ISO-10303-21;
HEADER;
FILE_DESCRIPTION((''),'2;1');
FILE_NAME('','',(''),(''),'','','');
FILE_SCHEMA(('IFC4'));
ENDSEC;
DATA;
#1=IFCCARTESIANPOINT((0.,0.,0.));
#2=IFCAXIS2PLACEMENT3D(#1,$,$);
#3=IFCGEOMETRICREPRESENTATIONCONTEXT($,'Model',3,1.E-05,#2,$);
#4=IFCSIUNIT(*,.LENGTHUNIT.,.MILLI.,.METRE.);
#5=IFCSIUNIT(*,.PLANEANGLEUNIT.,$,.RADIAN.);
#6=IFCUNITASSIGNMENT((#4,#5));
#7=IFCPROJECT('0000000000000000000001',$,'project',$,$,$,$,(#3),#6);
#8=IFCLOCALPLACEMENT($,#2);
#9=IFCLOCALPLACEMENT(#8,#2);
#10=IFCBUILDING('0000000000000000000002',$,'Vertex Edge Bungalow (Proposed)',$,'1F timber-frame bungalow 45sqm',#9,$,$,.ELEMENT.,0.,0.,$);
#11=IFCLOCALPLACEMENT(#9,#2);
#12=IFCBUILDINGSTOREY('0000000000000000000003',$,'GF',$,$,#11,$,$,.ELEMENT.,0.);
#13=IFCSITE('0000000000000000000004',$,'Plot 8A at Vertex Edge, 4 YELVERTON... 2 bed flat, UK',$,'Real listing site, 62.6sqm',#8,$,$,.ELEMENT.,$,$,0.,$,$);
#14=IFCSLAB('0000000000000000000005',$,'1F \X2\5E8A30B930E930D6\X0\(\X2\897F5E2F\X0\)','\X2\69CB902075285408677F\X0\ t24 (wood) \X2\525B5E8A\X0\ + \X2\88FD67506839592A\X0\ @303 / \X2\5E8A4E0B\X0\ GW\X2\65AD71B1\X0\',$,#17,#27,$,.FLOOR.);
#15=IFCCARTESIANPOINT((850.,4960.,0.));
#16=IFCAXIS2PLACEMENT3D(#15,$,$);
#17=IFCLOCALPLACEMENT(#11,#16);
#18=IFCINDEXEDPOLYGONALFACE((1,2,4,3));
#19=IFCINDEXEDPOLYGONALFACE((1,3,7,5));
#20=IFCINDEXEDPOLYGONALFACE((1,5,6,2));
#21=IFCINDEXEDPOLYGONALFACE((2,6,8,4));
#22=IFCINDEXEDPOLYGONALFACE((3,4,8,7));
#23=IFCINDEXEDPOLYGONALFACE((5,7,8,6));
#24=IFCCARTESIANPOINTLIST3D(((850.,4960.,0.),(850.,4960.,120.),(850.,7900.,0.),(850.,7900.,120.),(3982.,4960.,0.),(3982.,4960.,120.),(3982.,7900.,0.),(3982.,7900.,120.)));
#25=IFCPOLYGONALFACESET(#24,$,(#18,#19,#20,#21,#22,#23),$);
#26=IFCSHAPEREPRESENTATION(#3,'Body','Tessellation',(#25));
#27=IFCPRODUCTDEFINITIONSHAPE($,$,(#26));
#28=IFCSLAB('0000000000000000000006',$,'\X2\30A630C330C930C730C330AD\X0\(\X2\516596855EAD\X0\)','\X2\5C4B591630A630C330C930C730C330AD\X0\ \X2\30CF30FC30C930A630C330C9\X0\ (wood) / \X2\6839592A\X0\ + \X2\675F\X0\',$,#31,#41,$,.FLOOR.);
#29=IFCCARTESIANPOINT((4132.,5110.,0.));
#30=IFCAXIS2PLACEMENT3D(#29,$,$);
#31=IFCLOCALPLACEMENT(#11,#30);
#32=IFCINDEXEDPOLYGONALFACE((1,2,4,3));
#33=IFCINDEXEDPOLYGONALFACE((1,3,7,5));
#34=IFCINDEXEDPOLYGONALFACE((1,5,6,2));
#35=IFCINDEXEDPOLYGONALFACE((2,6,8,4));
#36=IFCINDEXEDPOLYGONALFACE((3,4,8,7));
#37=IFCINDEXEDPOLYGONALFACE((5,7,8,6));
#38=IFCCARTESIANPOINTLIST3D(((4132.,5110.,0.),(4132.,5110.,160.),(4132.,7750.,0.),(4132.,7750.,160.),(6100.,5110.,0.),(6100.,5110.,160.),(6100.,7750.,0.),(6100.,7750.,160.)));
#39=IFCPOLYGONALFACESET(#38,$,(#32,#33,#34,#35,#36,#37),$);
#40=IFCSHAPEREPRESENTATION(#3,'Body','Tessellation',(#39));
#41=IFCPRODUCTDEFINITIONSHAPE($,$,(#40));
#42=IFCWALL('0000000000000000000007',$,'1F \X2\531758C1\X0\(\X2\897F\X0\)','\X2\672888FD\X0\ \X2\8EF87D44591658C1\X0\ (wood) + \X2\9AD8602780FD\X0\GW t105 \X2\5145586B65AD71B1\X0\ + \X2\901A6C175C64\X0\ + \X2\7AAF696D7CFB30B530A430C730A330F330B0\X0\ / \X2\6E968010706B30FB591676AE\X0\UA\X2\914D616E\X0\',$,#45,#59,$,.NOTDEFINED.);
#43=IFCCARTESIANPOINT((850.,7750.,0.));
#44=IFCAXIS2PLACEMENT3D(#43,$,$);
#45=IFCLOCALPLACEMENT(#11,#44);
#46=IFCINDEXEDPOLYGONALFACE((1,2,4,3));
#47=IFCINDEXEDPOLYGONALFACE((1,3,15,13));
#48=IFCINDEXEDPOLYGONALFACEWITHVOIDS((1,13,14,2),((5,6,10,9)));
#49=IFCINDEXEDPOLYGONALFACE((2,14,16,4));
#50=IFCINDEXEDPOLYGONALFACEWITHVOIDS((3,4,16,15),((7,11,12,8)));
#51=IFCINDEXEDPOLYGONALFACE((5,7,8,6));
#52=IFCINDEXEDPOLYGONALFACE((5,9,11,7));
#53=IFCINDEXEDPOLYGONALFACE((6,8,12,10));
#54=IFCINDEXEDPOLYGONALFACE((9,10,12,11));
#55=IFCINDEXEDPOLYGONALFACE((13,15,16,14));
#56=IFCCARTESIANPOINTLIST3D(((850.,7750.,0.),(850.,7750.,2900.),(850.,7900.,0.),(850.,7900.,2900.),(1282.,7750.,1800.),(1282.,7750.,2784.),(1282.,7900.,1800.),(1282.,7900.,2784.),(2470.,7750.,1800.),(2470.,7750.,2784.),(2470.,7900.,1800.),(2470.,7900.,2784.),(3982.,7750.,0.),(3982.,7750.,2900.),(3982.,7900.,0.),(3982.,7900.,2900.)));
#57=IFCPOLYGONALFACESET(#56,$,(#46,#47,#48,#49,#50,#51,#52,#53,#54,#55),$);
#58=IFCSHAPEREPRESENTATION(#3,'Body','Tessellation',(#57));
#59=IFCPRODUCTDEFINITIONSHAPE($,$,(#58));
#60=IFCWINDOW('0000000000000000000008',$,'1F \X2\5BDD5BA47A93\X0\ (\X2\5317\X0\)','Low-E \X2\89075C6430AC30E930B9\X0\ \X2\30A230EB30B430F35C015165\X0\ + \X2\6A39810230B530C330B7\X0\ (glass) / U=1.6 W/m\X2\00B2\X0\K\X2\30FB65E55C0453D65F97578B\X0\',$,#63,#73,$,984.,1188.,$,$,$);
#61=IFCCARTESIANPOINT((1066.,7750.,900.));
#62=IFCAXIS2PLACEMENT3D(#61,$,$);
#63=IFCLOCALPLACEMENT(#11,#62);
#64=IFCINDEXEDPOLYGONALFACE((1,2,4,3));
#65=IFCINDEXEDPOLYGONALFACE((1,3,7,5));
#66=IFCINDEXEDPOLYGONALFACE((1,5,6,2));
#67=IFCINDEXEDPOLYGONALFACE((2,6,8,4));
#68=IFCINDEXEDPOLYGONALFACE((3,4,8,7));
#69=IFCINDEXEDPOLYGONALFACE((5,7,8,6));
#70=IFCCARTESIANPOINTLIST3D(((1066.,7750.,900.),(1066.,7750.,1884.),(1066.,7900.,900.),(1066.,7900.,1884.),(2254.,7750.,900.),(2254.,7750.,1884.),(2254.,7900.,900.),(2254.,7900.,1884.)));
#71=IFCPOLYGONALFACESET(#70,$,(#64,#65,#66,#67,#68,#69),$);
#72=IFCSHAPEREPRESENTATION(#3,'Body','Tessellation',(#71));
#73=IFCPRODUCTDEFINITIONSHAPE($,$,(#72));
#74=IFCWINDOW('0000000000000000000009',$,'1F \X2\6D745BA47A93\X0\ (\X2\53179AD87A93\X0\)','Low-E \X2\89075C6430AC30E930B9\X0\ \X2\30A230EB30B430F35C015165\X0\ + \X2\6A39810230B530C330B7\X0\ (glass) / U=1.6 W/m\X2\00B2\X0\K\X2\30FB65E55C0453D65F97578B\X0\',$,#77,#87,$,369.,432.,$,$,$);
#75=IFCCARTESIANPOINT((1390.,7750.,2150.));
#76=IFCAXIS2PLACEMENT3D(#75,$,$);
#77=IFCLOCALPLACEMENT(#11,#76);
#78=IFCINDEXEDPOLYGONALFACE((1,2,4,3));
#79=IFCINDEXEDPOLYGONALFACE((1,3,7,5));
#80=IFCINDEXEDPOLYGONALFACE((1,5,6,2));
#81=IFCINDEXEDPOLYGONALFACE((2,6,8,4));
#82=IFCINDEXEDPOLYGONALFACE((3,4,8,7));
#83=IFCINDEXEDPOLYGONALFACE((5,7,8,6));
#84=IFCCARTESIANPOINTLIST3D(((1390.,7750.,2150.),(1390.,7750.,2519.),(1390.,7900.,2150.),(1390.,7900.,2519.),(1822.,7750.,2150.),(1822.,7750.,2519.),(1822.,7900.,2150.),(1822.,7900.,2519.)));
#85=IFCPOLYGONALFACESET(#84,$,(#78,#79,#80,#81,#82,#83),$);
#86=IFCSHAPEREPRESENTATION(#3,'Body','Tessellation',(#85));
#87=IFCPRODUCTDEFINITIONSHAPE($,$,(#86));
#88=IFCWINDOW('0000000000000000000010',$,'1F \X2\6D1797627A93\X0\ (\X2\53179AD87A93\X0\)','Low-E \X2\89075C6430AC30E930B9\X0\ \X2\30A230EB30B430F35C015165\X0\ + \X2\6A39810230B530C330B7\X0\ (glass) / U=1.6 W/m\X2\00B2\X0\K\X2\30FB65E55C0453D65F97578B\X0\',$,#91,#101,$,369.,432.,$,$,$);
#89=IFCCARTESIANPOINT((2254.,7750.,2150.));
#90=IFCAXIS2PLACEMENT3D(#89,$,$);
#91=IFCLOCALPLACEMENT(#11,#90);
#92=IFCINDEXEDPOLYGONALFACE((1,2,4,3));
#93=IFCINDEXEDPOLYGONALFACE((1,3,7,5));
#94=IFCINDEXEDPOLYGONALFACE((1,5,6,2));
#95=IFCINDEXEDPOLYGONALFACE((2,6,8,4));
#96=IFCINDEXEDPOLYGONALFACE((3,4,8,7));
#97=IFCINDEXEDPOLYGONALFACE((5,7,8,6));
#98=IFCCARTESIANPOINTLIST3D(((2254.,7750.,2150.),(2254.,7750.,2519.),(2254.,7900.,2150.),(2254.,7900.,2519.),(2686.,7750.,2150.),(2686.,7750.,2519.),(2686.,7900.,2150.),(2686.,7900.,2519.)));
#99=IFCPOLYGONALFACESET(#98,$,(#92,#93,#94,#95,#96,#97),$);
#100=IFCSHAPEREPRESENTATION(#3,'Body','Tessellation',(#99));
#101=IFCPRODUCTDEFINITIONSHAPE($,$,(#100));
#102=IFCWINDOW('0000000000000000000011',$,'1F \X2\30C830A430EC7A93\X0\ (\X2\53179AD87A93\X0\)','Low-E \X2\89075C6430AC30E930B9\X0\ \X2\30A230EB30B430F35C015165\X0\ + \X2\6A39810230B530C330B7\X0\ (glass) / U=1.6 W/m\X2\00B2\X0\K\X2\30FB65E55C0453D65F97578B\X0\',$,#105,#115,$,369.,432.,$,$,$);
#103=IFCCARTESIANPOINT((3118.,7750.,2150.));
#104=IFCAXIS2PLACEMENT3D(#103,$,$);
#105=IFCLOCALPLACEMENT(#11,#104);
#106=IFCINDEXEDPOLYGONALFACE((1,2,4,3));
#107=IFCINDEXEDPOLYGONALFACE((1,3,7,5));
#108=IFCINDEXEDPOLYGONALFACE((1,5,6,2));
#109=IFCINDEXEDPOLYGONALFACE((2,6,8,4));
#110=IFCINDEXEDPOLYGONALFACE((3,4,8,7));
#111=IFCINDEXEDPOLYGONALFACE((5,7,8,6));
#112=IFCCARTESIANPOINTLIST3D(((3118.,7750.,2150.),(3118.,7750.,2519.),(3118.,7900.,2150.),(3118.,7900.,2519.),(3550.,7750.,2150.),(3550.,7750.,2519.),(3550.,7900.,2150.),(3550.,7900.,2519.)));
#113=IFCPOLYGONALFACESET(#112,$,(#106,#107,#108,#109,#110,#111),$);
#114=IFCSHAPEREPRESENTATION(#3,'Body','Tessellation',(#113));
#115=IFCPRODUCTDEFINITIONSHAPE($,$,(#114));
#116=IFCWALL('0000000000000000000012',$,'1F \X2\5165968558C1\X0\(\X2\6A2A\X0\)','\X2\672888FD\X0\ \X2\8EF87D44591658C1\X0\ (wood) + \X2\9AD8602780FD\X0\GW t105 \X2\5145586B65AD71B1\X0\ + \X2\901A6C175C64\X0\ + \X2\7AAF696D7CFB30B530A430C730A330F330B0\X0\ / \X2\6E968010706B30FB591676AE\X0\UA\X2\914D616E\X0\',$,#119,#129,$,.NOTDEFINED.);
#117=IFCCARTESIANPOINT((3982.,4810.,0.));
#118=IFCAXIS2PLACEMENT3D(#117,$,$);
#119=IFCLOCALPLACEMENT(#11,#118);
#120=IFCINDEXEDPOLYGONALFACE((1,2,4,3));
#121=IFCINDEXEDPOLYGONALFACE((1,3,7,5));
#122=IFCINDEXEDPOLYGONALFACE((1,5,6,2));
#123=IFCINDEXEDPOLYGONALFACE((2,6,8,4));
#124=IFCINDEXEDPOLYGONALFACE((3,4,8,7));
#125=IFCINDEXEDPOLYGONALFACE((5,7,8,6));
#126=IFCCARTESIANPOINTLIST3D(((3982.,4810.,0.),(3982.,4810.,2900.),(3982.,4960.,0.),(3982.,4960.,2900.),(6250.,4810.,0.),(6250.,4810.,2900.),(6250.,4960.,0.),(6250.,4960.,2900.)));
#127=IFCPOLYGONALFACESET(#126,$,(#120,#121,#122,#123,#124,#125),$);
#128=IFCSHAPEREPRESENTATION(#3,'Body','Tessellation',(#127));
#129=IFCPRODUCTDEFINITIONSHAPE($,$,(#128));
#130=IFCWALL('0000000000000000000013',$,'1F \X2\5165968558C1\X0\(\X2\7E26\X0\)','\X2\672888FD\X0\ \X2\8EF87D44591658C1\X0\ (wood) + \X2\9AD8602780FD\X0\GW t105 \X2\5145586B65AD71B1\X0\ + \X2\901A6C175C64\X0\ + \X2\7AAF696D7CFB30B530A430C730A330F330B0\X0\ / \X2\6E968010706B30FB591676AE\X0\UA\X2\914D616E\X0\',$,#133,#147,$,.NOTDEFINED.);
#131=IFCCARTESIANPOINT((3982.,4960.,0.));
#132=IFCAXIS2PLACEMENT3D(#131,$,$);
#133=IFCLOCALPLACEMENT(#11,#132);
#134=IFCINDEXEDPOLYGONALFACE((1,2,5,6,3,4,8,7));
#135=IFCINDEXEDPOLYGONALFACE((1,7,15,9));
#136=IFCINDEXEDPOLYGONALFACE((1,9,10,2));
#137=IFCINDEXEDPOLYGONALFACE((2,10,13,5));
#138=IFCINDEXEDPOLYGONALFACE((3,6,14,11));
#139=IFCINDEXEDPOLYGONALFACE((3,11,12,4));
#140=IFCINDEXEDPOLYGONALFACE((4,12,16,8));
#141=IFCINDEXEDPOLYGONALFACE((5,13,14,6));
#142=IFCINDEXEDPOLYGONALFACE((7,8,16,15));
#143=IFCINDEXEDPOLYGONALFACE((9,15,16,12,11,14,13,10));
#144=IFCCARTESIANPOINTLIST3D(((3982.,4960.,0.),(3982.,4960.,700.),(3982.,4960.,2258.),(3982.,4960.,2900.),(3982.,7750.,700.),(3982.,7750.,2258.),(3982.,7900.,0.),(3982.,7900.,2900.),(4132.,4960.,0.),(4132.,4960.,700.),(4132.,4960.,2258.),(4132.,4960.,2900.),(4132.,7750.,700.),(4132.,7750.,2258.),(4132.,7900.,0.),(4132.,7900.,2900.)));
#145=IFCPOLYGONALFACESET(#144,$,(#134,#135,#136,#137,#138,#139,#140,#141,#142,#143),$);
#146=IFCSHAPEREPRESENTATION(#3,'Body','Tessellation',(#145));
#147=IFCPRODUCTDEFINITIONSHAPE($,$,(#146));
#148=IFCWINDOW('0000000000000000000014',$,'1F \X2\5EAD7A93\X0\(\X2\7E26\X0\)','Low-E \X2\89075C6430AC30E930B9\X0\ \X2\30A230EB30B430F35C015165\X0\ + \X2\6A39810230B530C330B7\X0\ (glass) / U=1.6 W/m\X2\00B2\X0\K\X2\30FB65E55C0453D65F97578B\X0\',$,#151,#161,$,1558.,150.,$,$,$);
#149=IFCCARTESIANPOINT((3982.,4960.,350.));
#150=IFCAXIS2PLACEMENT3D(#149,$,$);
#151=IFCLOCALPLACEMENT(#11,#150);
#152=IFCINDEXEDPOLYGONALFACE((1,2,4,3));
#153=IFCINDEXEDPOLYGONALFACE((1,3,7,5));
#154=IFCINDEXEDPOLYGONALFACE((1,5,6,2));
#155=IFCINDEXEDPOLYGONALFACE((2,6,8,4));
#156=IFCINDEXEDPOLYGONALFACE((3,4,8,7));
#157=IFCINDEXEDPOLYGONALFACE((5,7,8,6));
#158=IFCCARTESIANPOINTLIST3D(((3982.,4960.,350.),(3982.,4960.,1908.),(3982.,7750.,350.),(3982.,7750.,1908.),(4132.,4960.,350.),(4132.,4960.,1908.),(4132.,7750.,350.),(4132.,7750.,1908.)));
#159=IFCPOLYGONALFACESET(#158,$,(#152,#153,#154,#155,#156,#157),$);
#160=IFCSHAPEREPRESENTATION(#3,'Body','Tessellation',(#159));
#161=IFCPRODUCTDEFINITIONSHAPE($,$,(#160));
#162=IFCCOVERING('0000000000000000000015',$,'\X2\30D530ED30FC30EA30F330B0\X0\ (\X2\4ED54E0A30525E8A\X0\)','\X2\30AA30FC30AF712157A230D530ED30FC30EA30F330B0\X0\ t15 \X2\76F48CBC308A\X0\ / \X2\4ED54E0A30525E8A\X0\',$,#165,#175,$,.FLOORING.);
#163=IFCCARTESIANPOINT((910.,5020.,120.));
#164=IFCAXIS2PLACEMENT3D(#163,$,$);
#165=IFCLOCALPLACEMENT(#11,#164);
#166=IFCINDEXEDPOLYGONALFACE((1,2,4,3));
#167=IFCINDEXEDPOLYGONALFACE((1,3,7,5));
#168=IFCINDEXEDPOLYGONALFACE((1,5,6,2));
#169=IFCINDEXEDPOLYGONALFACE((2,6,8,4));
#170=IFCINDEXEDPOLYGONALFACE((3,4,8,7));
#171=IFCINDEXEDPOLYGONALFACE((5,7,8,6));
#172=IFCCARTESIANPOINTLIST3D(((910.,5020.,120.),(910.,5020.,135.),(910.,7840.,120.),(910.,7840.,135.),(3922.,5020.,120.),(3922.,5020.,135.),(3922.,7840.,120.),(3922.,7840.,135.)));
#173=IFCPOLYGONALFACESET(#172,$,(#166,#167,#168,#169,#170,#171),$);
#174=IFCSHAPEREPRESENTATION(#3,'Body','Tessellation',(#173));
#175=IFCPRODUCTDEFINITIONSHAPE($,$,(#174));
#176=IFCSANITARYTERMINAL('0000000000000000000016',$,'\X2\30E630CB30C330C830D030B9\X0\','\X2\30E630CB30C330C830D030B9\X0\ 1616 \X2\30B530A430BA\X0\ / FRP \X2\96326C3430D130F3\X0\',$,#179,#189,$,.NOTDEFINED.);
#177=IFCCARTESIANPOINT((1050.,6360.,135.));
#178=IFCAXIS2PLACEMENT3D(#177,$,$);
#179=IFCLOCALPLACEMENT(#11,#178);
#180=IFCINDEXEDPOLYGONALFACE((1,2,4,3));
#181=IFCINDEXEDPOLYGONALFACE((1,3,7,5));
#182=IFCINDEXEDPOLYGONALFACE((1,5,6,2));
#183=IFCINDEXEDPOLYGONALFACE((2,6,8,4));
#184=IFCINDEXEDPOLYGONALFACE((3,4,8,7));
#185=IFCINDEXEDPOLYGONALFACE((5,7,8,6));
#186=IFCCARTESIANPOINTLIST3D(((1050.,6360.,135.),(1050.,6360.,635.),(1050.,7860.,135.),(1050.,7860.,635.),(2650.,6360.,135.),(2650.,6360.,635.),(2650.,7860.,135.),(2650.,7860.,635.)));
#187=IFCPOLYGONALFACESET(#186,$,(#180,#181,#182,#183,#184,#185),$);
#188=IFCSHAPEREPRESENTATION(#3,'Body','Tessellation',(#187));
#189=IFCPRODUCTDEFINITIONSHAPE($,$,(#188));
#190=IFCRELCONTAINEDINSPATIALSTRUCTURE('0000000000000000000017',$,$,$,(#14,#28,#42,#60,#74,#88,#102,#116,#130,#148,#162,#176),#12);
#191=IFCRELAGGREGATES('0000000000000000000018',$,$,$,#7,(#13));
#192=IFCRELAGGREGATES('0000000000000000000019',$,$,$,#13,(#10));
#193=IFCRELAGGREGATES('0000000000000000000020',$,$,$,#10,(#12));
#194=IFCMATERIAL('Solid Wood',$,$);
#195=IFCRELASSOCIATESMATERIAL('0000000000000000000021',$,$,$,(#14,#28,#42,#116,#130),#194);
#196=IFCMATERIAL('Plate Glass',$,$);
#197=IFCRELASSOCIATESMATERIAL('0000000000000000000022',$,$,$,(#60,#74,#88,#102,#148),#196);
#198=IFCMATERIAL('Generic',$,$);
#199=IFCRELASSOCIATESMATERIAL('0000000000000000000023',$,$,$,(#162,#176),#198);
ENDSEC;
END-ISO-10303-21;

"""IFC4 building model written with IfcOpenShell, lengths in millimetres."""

from ifc_helpers import new_model, si_unit, frame, frame_2d, origin, place, context, project, spatial, rectangle, extrude, material, element, fill, save


model = new_model("IFC4")

# Units and contexts
model_context = context("Model", 3, precision=1e-05, world=origin())
ifc_project = project(units=[si_unit("LENGTHUNIT", "METRE", prefix="MILLI"), si_unit("PLANEANGLEUNIT", "RADIAN")], contexts=[model_context])

# Site, building, storey
site_placement = place(None, origin())
site = spatial("IfcSite", under=ifc_project, at=site_placement, Name="Plot 8A at Vertex Edge, 4 YELVERTON... 2 bed flat, UK", ObjectType="Real listing site, 62.6sqm", CompositionType="ELEMENT", RefElevation=0.0)
building_placement = place(site_placement, origin())
building = spatial("IfcBuilding", under=site, at=building_placement, Name="Vertex Edge Bungalow (Proposed)", ObjectType="1F timber-frame bungalow 45sqm", CompositionType="ELEMENT", ElevationOfRefHeight=0.0, ElevationOfTerrain=0.0)
storey_placement = place(building_placement, origin())
storey = spatial("IfcBuildingStorey", under=building, at=storey_placement, Name="GF", CompositionType="ELEMENT", Elevation=0.0)

# Slabs
ifc_material_1 = material(Name="Solid Wood")
slab_1_placement = place(storey_placement, frame((850.0, 4960.0, 0.0)))
element("IfcSlab", 1, at=slab_1_placement, inside=storey, material=ifc_material_1, Name="1F 床スラブ(西帯)", Description="構造用合板 t24 (wood) 剛床 + 製材根太 @303 / 床下 GW断熱", PredefinedType="FLOOR", context=model_context, shape_type="SweptSolid", body=[
    extrude(rectangle(XDim=3132.0, YDim=2940.0, at=frame_2d((1566.0, 1470.0))), frame((850.0, 4960.0, 0.0)), (0.0, 0.0, 1.0), 120.0),
])
slab_2_placement = place(storey_placement, frame((4132.0, 5110.0, 0.0)))
element("IfcSlab", 2, at=slab_2_placement, inside=storey, material=ifc_material_1, Name="ウッドデッキ(入隅庭)", Description="屋外ウッドデッキ ハードウッド (wood) / 根太 + 束", PredefinedType="FLOOR", context=model_context, shape_type="SweptSolid", body=[
    extrude(rectangle(XDim=1968.0, YDim=2640.0, at=frame_2d((984.0, 1320.0))), frame((4132.0, 5110.0, 0.0)), (0.0, 0.0, 1.0), 160.0),
])

# Wall, openings, windows
wall_1_placement = place(storey_placement, frame((850.0, 7750.0, 0.0)))
wall_1 = element("IfcWall", 3, at=wall_1_placement, inside=storey, material=ifc_material_1, Name="1F 北壁(西)", Description="木製 軸組外壁 (wood) + 高性能GW t105 充填断熱 + 通気層 + 窯業系サイディング / 準耐火・外皮UA配慮", PredefinedType="NOTDEFINED", context=model_context, shape_type="SweptSolid", body=[
    extrude(rectangle(XDim=3132.0, YDim=150.0, at=frame_2d((1566.0, 75.0))), frame((850.0, 7750.0, 0.0)), (0.0, 0.0, 1.0), 2900.0),
])
opening_1_placement = place(storey_placement, frame((1066.0, 7750.0, 900.0)))
opening_1 = element("IfcOpeningElement", 4, at=opening_1_placement, cuts=wall_1, PredefinedType="NOTDEFINED", context=model_context, shape_type="SweptSolid", body=[
    extrude(rectangle(XDim=1188.0, YDim=150.0, at=frame_2d((594.0, 75.0))), frame((1066.0, 7750.0, 900.0)), (0.0, 0.0, 1.0), 984.0),
])
opening_2_placement = place(storey_placement, frame((1390.0, 7750.0, 2150.0)))
opening_2 = element("IfcOpeningElement", 5, at=opening_2_placement, cuts=wall_1, PredefinedType="NOTDEFINED", context=model_context, shape_type="SweptSolid", body=[
    extrude(rectangle(XDim=432.0, YDim=150.0, at=frame_2d((216.0, 75.0))), frame((1390.0, 7750.0, 2150.0)), (0.0, 0.0, 1.0), 369.0),
])
opening_3_placement = place(storey_placement, frame((2254.0, 7750.0, 2150.0)))
opening_3 = element("IfcOpeningElement", 6, at=opening_3_placement, cuts=wall_1, PredefinedType="NOTDEFINED", context=model_context, shape_type="SweptSolid", body=[
    extrude(rectangle(XDim=432.0, YDim=150.0, at=frame_2d((216.0, 75.0))), frame((2254.0, 7750.0, 2150.0)), (0.0, 0.0, 1.0), 369.0),
])
opening_4_placement = place(storey_placement, frame((3118.0, 7750.0, 2150.0)))
opening_4 = element("IfcOpeningElement", 7, at=opening_4_placement, cuts=wall_1, PredefinedType="NOTDEFINED", context=model_context, shape_type="SweptSolid", body=[
    extrude(rectangle(XDim=432.0, YDim=150.0, at=frame_2d((216.0, 75.0))), frame((3118.0, 7750.0, 2150.0)), (0.0, 0.0, 1.0), 369.0),
])
ifc_material_2 = material(Name="Plate Glass")
window_1_placement = place(storey_placement, frame((1066.0, 7750.0, 900.0)))
window_1 = element("IfcWindow", 8, at=window_1_placement, inside=storey, material=ifc_material_2, Name="1F 寝室窓 (北)", Description="Low-E 複層ガラス アルゴン封入 + 樹脂サッシ (glass) / U=1.6 W/m²K・日射取得型", OverallHeight=984.0, OverallWidth=1188.0, context=model_context, shape_type="SweptSolid", body=[
    extrude(rectangle(XDim=1188.0, YDim=150.0, at=frame_2d((594.0, 75.0))), frame((1066.0, 7750.0, 900.0)), (0.0, 0.0, 1.0), 984.0),
])
fill(opening_1, window_1)
window_2_placement = place(storey_placement, frame((1390.0, 7750.0, 2150.0)))
window_2 = element("IfcWindow", 9, at=window_2_placement, inside=storey, material=ifc_material_2, Name="1F 浴室窓 (北高窓)", Description="Low-E 複層ガラス アルゴン封入 + 樹脂サッシ (glass) / U=1.6 W/m²K・日射取得型", OverallHeight=369.0, OverallWidth=432.0, context=model_context, shape_type="SweptSolid", body=[
    extrude(rectangle(XDim=432.0, YDim=150.0, at=frame_2d((216.0, 75.0))), frame((1390.0, 7750.0, 2150.0)), (0.0, 0.0, 1.0), 369.0),
])
fill(opening_2, window_2)
window_3_placement = place(storey_placement, frame((2254.0, 7750.0, 2150.0)))
window_3 = element("IfcWindow", 10, at=window_3_placement, inside=storey, material=ifc_material_2, Name="1F 洗面窓 (北高窓)", Description="Low-E 複層ガラス アルゴン封入 + 樹脂サッシ (glass) / U=1.6 W/m²K・日射取得型", OverallHeight=369.0, OverallWidth=432.0, context=model_context, shape_type="SweptSolid", body=[
    extrude(rectangle(XDim=432.0, YDim=150.0, at=frame_2d((216.0, 75.0))), frame((2254.0, 7750.0, 2150.0)), (0.0, 0.0, 1.0), 369.0),
])
fill(opening_3, window_3)
window_4_placement = place(storey_placement, frame((3118.0, 7750.0, 2150.0)))
window_4 = element("IfcWindow", 11, at=window_4_placement, inside=storey, material=ifc_material_2, Name="1F トイレ窓 (北高窓)", Description="Low-E 複層ガラス アルゴン封入 + 樹脂サッシ (glass) / U=1.6 W/m²K・日射取得型", OverallHeight=369.0, OverallWidth=432.0, context=model_context, shape_type="SweptSolid", body=[
    extrude(rectangle(XDim=432.0, YDim=150.0, at=frame_2d((216.0, 75.0))), frame((3118.0, 7750.0, 2150.0)), (0.0, 0.0, 1.0), 369.0),
])
fill(opening_4, window_4)

# Wall
wall_2_placement = place(storey_placement, frame((3982.0, 4810.0, 0.0)))
element("IfcWall", 12, at=wall_2_placement, inside=storey, material=ifc_material_1, Name="1F 入隅壁(横)", Description="木製 軸組外壁 (wood) + 高性能GW t105 充填断熱 + 通気層 + 窯業系サイディング / 準耐火・外皮UA配慮", PredefinedType="NOTDEFINED", context=model_context, shape_type="SweptSolid", body=[
    extrude(rectangle(XDim=2268.0, YDim=150.0, at=frame_2d((1134.0, 75.0))), frame((3982.0, 4810.0, 0.0)), (0.0, 0.0, 1.0), 2900.0),
])

# Wall, opening, window
wall_3_placement = place(storey_placement, frame((3982.0, 4960.0, 0.0)))
wall_3 = element("IfcWall", 13, at=wall_3_placement, inside=storey, material=ifc_material_1, Name="1F 入隅壁(縦)", Description="木製 軸組外壁 (wood) + 高性能GW t105 充填断熱 + 通気層 + 窯業系サイディング / 準耐火・外皮UA配慮", PredefinedType="NOTDEFINED", context=model_context, shape_type="SweptSolid", body=[
    extrude(rectangle(XDim=150.0, YDim=2940.0, at=frame_2d((75.0, 1470.0))), frame((3982.0, 4960.0, 0.0)), (0.0, 0.0, 1.0), 2900.0),
])
opening_5_placement = place(storey_placement, frame((3982.0, 4960.0, 350.0)))
opening_5 = element("IfcOpeningElement", 14, at=opening_5_placement, cuts=wall_3, PredefinedType="NOTDEFINED", context=model_context, shape_type="SweptSolid", body=[
    extrude(rectangle(XDim=150.0, YDim=2790.0, at=frame_2d((75.0, 1395.0))), frame((3982.0, 4960.0, 350.0)), (0.0, 0.0, 1.0), 1558.0),
])
window_5_placement = place(storey_placement, frame((3982.0, 4960.0, 350.0)))
window_5 = element("IfcWindow", 15, at=window_5_placement, inside=storey, material=ifc_material_2, Name="1F 庭窓(縦)", Description="Low-E 複層ガラス アルゴン封入 + 樹脂サッシ (glass) / U=1.6 W/m²K・日射取得型", OverallHeight=1558.0, OverallWidth=150.0, context=model_context, shape_type="SweptSolid", body=[
    extrude(rectangle(XDim=150.0, YDim=2790.0, at=frame_2d((75.0, 1395.0))), frame((3982.0, 4960.0, 350.0)), (0.0, 0.0, 1.0), 1558.0),
])
fill(opening_5, window_5)

# Covering
ifc_material_3 = material(Name="Generic")
covering_placement = place(storey_placement, frame((910.0, 5020.0, 120.0)))
element("IfcCovering", 16, at=covering_placement, inside=storey, material=ifc_material_3, Name="フローリング (仕上げ床)", Description="オーク無垢フローリング t15 直貼り / 仕上げ床", PredefinedType="FLOORING", context=model_context, shape_type="SweptSolid", body=[
    extrude(rectangle(XDim=3012.0, YDim=2820.0, at=frame_2d((1506.0, 1410.0))), frame((910.0, 5020.0, 120.0)), (0.0, 0.0, 1.0), 15.0),
])

# Sanitary terminal
sanitary_terminal_1_placement = place(storey_placement, frame((1050.0, 6360.0, 135.0)))
element("IfcSanitaryTerminal", 17, at=sanitary_terminal_1_placement, inside=storey, material=ifc_material_3, Name="ユニットバス", Description="ユニットバス 1616 サイズ / FRP 防水パン", PredefinedType="NOTDEFINED", context=model_context, shape_type="SweptSolid", body=[
    extrude(rectangle(XDim=1600.0, YDim=1500.0, at=frame_2d((800.0, 750.0))), frame((1050.0, 6360.0, 135.0)), (0.0, 0.0, 1.0), 500.0),
])

save(model, "model.ifc")
